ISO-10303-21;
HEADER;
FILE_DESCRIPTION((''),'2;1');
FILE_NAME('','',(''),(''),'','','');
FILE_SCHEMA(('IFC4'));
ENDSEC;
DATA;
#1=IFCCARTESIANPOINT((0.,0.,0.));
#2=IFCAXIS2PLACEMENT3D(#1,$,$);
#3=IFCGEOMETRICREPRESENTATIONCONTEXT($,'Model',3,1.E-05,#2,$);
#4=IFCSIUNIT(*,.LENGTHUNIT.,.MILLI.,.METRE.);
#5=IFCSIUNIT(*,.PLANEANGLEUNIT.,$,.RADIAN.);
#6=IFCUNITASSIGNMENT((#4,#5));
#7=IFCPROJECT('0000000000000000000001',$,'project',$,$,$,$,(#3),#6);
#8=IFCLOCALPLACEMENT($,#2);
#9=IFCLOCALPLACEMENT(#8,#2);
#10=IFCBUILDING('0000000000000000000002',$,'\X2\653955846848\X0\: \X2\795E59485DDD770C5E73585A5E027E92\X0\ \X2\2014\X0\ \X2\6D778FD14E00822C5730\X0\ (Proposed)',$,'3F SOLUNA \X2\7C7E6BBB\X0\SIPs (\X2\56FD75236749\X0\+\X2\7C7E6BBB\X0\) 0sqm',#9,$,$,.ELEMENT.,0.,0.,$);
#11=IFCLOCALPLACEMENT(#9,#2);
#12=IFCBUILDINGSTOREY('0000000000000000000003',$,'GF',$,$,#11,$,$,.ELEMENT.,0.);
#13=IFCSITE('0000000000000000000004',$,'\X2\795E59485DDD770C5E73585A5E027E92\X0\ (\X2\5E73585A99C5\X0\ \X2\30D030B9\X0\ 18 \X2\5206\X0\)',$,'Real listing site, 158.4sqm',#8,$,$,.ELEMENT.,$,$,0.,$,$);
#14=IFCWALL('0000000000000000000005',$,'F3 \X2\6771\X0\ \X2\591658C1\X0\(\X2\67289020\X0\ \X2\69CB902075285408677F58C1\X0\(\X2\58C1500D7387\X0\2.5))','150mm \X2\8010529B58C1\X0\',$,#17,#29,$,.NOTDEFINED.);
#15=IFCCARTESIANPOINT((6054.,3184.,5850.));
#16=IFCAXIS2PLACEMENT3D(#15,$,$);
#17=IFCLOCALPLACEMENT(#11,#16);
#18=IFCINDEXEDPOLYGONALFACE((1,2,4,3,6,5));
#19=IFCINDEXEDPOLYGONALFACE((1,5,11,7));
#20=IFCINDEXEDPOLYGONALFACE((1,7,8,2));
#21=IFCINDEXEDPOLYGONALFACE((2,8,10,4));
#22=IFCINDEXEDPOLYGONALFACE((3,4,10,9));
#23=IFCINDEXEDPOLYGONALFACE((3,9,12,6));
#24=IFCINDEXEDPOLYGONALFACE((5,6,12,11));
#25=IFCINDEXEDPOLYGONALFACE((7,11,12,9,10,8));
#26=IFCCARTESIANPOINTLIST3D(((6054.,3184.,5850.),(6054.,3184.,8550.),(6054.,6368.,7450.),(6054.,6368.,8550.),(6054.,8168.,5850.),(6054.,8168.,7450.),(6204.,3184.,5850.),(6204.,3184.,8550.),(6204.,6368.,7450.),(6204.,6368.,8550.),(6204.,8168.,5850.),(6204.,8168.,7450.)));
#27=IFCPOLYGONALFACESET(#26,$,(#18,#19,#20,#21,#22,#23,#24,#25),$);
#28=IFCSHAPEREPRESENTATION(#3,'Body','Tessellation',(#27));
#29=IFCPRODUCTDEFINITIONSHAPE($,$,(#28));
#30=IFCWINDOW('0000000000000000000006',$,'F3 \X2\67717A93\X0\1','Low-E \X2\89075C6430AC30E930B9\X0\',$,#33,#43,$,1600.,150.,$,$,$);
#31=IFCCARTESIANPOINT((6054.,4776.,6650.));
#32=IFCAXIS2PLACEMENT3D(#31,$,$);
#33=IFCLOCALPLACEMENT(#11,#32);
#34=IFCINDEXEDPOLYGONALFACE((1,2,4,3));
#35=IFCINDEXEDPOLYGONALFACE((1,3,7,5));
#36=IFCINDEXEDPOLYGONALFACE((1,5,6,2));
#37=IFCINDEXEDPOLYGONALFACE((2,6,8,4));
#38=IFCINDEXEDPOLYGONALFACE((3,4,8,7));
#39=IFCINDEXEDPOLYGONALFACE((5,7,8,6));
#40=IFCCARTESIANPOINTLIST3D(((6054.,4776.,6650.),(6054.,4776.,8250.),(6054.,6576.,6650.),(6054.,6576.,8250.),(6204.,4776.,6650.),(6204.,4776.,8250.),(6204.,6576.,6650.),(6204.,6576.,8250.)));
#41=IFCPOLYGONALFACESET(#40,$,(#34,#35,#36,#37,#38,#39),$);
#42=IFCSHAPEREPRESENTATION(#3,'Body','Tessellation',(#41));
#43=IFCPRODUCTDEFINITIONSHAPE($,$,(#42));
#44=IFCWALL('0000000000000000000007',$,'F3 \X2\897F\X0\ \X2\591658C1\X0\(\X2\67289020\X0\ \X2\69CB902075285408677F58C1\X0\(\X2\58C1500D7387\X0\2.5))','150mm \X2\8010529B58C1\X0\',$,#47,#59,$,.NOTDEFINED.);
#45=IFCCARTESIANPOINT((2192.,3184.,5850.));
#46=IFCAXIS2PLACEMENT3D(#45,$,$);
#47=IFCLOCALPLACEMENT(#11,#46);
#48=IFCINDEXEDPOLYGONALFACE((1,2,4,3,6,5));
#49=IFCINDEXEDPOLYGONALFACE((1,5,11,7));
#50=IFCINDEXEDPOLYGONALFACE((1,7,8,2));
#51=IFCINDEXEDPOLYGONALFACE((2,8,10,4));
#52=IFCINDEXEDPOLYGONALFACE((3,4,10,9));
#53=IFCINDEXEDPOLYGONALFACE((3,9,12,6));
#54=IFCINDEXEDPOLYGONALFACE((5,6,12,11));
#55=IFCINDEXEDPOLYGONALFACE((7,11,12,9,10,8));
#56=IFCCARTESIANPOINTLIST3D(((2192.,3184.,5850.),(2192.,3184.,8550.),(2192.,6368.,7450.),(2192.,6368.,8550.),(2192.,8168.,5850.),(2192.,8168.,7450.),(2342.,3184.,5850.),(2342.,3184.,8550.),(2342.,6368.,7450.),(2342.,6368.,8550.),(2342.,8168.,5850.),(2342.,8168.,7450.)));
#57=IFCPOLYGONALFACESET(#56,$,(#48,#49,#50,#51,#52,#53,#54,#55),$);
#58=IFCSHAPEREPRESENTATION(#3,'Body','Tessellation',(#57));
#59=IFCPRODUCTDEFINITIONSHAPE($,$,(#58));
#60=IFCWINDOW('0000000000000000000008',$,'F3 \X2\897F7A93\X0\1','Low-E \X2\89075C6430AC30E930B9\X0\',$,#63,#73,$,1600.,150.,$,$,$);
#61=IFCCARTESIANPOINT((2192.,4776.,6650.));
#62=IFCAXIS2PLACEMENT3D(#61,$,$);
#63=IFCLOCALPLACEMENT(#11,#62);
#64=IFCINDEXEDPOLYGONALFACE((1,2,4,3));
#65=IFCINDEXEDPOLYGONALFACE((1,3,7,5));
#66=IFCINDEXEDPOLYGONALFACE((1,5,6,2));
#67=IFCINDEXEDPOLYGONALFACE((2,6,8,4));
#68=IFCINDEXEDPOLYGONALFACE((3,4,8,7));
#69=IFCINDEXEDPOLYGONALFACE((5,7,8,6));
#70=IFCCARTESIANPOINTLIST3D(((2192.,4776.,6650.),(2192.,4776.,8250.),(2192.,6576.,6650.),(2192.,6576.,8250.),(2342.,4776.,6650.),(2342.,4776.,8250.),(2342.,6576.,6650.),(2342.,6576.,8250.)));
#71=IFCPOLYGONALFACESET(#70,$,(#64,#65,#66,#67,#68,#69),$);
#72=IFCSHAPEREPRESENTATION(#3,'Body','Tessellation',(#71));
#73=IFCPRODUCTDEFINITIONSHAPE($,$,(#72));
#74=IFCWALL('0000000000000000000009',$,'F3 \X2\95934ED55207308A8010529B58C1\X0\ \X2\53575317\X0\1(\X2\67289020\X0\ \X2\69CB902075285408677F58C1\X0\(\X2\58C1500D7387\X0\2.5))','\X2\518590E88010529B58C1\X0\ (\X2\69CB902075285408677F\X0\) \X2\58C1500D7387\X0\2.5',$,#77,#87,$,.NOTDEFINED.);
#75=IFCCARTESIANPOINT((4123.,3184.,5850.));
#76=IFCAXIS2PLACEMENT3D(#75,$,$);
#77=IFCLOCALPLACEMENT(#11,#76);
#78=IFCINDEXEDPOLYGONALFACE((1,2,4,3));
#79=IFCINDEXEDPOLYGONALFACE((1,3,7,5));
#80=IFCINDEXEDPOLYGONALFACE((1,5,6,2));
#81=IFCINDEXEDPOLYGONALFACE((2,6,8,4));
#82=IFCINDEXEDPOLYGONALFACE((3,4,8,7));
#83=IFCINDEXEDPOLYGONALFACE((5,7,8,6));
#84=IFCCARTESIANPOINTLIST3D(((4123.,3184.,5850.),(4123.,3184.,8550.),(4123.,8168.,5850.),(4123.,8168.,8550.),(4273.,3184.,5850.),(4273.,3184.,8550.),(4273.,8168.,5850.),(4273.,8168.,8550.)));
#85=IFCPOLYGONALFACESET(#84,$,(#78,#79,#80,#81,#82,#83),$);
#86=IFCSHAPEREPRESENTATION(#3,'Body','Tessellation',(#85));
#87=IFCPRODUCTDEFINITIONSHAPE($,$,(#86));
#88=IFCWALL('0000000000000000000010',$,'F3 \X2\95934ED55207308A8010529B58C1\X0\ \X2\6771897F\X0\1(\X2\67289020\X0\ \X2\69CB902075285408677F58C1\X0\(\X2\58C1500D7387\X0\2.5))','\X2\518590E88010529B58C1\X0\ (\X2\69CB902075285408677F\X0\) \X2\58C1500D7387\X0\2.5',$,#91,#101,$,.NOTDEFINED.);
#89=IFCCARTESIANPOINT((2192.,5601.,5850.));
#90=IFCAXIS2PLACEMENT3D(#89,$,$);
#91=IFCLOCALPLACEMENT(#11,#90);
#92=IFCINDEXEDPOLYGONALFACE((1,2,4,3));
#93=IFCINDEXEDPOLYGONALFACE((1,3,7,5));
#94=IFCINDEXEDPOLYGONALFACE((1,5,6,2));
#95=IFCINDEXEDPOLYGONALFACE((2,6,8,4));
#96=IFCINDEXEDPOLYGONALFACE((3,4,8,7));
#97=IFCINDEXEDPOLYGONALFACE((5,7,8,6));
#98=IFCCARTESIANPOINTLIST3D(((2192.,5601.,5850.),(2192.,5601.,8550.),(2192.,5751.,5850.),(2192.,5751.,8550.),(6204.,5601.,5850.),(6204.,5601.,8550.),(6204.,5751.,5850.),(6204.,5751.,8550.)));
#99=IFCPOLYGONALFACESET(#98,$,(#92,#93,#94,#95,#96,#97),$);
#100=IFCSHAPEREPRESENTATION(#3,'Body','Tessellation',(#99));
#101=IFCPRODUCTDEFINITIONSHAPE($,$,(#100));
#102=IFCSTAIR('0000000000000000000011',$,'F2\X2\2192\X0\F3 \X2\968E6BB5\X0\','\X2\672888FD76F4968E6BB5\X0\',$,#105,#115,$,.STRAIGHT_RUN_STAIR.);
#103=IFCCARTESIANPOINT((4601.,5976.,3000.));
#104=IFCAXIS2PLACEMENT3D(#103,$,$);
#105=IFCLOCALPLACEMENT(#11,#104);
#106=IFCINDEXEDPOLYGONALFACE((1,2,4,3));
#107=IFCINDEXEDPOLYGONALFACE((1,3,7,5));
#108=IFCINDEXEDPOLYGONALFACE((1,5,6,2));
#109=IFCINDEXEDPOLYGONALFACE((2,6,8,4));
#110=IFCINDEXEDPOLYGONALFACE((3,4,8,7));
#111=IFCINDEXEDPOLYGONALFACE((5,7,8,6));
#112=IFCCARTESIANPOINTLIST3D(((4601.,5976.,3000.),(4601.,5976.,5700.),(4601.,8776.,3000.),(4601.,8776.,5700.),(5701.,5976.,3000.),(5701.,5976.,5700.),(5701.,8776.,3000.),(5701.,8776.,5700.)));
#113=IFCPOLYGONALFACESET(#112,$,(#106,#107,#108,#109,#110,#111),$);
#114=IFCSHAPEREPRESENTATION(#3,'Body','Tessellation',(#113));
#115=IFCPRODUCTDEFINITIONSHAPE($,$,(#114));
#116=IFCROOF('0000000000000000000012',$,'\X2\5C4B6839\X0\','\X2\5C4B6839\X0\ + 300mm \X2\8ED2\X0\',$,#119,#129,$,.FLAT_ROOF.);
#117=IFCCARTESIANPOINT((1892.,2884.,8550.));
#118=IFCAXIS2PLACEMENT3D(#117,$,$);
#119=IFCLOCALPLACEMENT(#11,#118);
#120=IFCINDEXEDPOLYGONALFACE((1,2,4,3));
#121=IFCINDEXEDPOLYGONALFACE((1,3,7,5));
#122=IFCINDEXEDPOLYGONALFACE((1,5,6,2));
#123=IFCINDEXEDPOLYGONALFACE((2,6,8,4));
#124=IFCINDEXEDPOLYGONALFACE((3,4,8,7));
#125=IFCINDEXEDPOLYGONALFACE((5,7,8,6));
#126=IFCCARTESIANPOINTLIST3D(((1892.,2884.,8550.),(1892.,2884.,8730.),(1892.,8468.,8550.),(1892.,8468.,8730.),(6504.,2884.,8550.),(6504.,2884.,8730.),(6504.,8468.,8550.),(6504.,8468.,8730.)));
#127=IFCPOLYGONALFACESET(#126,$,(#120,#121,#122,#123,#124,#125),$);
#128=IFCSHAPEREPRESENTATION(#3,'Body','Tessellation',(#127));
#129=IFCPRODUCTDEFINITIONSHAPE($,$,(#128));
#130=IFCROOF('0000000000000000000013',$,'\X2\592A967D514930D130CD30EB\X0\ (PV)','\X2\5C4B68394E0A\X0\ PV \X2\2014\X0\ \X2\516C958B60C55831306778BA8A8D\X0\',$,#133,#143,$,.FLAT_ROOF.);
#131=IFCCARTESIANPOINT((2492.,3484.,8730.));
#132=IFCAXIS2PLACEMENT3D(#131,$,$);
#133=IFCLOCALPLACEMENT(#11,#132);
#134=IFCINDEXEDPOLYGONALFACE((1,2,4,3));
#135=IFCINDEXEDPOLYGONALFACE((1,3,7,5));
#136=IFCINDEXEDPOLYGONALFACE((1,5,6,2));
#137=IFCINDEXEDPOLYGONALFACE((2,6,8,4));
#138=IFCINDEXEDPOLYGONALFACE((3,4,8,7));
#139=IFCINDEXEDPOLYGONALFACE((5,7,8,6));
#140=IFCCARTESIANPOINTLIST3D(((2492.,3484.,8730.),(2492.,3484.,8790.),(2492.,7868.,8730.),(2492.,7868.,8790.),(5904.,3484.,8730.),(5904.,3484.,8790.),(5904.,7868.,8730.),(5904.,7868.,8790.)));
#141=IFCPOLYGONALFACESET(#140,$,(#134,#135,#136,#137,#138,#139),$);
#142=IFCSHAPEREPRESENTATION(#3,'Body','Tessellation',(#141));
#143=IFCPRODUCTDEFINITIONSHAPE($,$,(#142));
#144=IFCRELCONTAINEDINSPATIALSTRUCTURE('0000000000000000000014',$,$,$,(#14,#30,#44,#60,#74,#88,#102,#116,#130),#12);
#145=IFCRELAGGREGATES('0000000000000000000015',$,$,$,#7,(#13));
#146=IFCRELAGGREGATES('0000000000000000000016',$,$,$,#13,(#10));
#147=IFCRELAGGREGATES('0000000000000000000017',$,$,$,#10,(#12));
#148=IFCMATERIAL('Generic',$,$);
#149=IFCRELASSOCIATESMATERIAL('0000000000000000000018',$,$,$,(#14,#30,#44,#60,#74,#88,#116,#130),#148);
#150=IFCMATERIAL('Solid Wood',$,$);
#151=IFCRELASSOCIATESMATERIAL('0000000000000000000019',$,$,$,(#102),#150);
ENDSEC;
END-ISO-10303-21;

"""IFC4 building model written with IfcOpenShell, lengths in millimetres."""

from ifc_helpers import new_model, si_unit, frame, frame_2d, origin, place, context, project, spatial, rectangle, extrude, material, element, fill, save


model = new_model("IFC4")

# Units and contexts
model_context = context("Model", 3, precision=1e-05, world=origin())
ifc_project = project(units=[si_unit("LENGTHUNIT", "METRE", prefix="MILLI"), si_unit("PLANEANGLEUNIT", "RADIAN")], contexts=[model_context])

# Site, building, storey
site_placement = place(None, origin())
site = spatial("IfcSite", under=ifc_project, at=site_placement, Name="神奈川県平塚市纒 (平塚駅 バス 18 分)", ObjectType="Real listing site, 158.4sqm", CompositionType="ELEMENT", RefElevation=0.0)
building_placement = place(site_placement, origin())
building = spatial("IfcBuilding", under=site, at=building_placement, Name="改善案: 神奈川県平塚市纒 — 海近一般地 (Proposed)", ObjectType="3F SOLUNA 籾殻SIPs (国産杉+籾殻) 0sqm", CompositionType="ELEMENT", ElevationOfRefHeight=0.0, ElevationOfTerrain=0.0)
storey_placement = place(building_placement, origin())
storey = spatial("IfcBuildingStorey", under=building, at=storey_placement, Name="GF", CompositionType="ELEMENT", Elevation=0.0)

# Shared definitions
ifc_material_1 = material(Name="Generic")

# Walls, openings, windows
wall_1_placement = place(storey_placement, frame((6054.0, 3184.0, 5850.0)))
wall_1 = element("IfcWall", 1, at=wall_1_placement, inside=storey, material=ifc_material_1, Name="F3 東 外壁(木造 構造用合板壁(壁倍率2.5))", Description="150mm 耐力壁", PredefinedType="NOTDEFINED", context=model_context, shape_type="SweptSolid", body=[
    extrude(rectangle(XDim=150.0, YDim=4984.0, at=frame_2d((75.0, 2492.0))), frame((6054.0, 3184.0, 5850.0)), (0.0, 0.0, 1.0), 2700.0),
])
opening_1_placement = place(storey_placement, frame((6054.0, 4776.0, 6650.0)))
opening_1 = element("IfcOpeningElement", 2, at=opening_1_placement, cuts=wall_1, PredefinedType="NOTDEFINED", context=model_context, shape_type="SweptSolid", body=[
    extrude(rectangle(XDim=150.0, YDim=1800.0, at=frame_2d((75.0, 900.0))), frame((6054.0, 4776.0, 6650.0)), (0.0, 0.0, 1.0), 1600.0),
])
window_1_placement = place(storey_placement, frame((6054.0, 4776.0, 6650.0)))
window_1 = element("IfcWindow", 3, at=window_1_placement, inside=storey, material=ifc_material_1, Name="F3 東窓1", Description="Low-E 複層ガラス", OverallHeight=1600.0, OverallWidth=150.0, context=model_context, shape_type="SweptSolid", body=[
    extrude(rectangle(XDim=150.0, YDim=1800.0, at=frame_2d((75.0, 900.0))), frame((6054.0, 4776.0, 6650.0)), (0.0, 0.0, 1.0), 1600.0),
])
fill(opening_1, window_1)
wall_2_placement = place(storey_placement, frame((2192.0, 3184.0, 5850.0)))
wall_2 = element("IfcWall", 4, at=wall_2_placement, inside=storey, material=ifc_material_1, Name="F3 西 外壁(木造 構造用合板壁(壁倍率2.5))", Description="150mm 耐力壁", PredefinedType="NOTDEFINED", context=model_context, shape_type="SweptSolid", body=[
    extrude(rectangle(XDim=150.0, YDim=4984.0, at=frame_2d((75.0, 2492.0))), frame((2192.0, 3184.0, 5850.0)), (0.0, 0.0, 1.0), 2700.0),
])
opening_2_placement = place(storey_placement, frame((2192.0, 4776.0, 6650.0)))
opening_2 = element("IfcOpeningElement", 5, at=opening_2_placement, cuts=wall_2, PredefinedType="NOTDEFINED", context=model_context, shape_type="SweptSolid", body=[
    extrude(rectangle(XDim=150.0, YDim=1800.0, at=frame_2d((75.0, 900.0))), frame((2192.0, 4776.0, 6650.0)), (0.0, 0.0, 1.0), 1600.0),
])
window_2_placement = place(storey_placement, frame((2192.0, 4776.0, 6650.0)))
window_2 = element("IfcWindow", 6, at=window_2_placement, inside=storey, material=ifc_material_1, Name="F3 西窓1", Description="Low-E 複層ガラス", OverallHeight=1600.0, OverallWidth=150.0, context=model_context, shape_type="SweptSolid", body=[
    extrude(rectangle(XDim=150.0, YDim=1800.0, at=frame_2d((75.0, 900.0))), frame((2192.0, 4776.0, 6650.0)), (0.0, 0.0, 1.0), 1600.0),
])
fill(opening_2, window_2)

# Walls
wall_3_placement = place(storey_placement, frame((4123.0, 3184.0, 5850.0)))
element("IfcWall", 7, at=wall_3_placement, inside=storey, material=ifc_material_1, Name="F3 間仕切り耐力壁 南北1(木造 構造用合板壁(壁倍率2.5))", Description="内部耐力壁 (構造用合板) 壁倍率2.5", PredefinedType="NOTDEFINED", context=model_context, shape_type="SweptSolid", body=[
    extrude(rectangle(XDim=150.0, YDim=4984.0, at=frame_2d((75.0, 2492.0))), frame((4123.0, 3184.0, 5850.0)), (0.0, 0.0, 1.0), 2700.0),
])
wall_4_placement = place(storey_placement, frame((2192.0, 5601.0, 5850.0)))
element("IfcWall", 8, at=wall_4_placement, inside=storey, material=ifc_material_1, Name="F3 間仕切り耐力壁 東西1(木造 構造用合板壁(壁倍率2.5))", Description="内部耐力壁 (構造用合板) 壁倍率2.5", PredefinedType="NOTDEFINED", context=model_context, shape_type="SweptSolid", body=[
    extrude(rectangle(XDim=4012.0, YDim=150.0, at=frame_2d((2006.0, 75.0))), frame((2192.0, 5601.0, 5850.0)), (0.0, 0.0, 1.0), 2700.0),
])

# Stair
ifc_material_2 = material(Name="Solid Wood")
stair_placement = place(storey_placement, frame((4601.0, 5976.0, 3000.0)))
element("IfcStair", 9, at=stair_placement, inside=storey, material=ifc_material_2, Name="F2→F3 階段", Description="木製直階段", PredefinedType="STRAIGHT_RUN_STAIR", context=model_context, shape_type="SweptSolid", body=[
    extrude(rectangle(XDim=1100.0, YDim=2800.0, at=frame_2d((550.0, 1400.0))), frame((4601.0, 5976.0, 3000.0)), (0.0, 0.0, 1.0), 2700.0),
])

# Roofs
roof_1_placement = place(storey_placement, frame((1892.0, 2884.0, 8550.0)))
element("IfcRoof", 10, at=roof_1_placement, inside=storey, material=ifc_material_1, Name="屋根", Description="屋根 + 300mm 軒", PredefinedType="FLAT_ROOF", context=model_context, shape_type="SweptSolid", body=[
    extrude(rectangle(XDim=4612.0, YDim=5584.0, at=frame_2d((2306.0, 2792.0))), frame((1892.0, 2884.0, 8550.0)), (0.0, 0.0, 1.0), 180.0),
])
roof_2_placement = place(storey_placement, frame((2492.0, 3484.0, 8730.0)))
element("IfcRoof", 11, at=roof_2_placement, inside=storey, material=ifc_material_1, Name="太陽光パネル (PV)", Description="屋根上 PV — 公開情報で確認", PredefinedType="FLAT_ROOF", context=model_context, shape_type="SweptSolid", body=[
    extrude(rectangle(XDim=3412.0, YDim=4384.0, at=frame_2d((1706.0, 2192.0))), frame((2492.0, 3484.0, 8730.0)), (0.0, 0.0, 1.0), 60.0),
])

save(model, "model.ifc")
